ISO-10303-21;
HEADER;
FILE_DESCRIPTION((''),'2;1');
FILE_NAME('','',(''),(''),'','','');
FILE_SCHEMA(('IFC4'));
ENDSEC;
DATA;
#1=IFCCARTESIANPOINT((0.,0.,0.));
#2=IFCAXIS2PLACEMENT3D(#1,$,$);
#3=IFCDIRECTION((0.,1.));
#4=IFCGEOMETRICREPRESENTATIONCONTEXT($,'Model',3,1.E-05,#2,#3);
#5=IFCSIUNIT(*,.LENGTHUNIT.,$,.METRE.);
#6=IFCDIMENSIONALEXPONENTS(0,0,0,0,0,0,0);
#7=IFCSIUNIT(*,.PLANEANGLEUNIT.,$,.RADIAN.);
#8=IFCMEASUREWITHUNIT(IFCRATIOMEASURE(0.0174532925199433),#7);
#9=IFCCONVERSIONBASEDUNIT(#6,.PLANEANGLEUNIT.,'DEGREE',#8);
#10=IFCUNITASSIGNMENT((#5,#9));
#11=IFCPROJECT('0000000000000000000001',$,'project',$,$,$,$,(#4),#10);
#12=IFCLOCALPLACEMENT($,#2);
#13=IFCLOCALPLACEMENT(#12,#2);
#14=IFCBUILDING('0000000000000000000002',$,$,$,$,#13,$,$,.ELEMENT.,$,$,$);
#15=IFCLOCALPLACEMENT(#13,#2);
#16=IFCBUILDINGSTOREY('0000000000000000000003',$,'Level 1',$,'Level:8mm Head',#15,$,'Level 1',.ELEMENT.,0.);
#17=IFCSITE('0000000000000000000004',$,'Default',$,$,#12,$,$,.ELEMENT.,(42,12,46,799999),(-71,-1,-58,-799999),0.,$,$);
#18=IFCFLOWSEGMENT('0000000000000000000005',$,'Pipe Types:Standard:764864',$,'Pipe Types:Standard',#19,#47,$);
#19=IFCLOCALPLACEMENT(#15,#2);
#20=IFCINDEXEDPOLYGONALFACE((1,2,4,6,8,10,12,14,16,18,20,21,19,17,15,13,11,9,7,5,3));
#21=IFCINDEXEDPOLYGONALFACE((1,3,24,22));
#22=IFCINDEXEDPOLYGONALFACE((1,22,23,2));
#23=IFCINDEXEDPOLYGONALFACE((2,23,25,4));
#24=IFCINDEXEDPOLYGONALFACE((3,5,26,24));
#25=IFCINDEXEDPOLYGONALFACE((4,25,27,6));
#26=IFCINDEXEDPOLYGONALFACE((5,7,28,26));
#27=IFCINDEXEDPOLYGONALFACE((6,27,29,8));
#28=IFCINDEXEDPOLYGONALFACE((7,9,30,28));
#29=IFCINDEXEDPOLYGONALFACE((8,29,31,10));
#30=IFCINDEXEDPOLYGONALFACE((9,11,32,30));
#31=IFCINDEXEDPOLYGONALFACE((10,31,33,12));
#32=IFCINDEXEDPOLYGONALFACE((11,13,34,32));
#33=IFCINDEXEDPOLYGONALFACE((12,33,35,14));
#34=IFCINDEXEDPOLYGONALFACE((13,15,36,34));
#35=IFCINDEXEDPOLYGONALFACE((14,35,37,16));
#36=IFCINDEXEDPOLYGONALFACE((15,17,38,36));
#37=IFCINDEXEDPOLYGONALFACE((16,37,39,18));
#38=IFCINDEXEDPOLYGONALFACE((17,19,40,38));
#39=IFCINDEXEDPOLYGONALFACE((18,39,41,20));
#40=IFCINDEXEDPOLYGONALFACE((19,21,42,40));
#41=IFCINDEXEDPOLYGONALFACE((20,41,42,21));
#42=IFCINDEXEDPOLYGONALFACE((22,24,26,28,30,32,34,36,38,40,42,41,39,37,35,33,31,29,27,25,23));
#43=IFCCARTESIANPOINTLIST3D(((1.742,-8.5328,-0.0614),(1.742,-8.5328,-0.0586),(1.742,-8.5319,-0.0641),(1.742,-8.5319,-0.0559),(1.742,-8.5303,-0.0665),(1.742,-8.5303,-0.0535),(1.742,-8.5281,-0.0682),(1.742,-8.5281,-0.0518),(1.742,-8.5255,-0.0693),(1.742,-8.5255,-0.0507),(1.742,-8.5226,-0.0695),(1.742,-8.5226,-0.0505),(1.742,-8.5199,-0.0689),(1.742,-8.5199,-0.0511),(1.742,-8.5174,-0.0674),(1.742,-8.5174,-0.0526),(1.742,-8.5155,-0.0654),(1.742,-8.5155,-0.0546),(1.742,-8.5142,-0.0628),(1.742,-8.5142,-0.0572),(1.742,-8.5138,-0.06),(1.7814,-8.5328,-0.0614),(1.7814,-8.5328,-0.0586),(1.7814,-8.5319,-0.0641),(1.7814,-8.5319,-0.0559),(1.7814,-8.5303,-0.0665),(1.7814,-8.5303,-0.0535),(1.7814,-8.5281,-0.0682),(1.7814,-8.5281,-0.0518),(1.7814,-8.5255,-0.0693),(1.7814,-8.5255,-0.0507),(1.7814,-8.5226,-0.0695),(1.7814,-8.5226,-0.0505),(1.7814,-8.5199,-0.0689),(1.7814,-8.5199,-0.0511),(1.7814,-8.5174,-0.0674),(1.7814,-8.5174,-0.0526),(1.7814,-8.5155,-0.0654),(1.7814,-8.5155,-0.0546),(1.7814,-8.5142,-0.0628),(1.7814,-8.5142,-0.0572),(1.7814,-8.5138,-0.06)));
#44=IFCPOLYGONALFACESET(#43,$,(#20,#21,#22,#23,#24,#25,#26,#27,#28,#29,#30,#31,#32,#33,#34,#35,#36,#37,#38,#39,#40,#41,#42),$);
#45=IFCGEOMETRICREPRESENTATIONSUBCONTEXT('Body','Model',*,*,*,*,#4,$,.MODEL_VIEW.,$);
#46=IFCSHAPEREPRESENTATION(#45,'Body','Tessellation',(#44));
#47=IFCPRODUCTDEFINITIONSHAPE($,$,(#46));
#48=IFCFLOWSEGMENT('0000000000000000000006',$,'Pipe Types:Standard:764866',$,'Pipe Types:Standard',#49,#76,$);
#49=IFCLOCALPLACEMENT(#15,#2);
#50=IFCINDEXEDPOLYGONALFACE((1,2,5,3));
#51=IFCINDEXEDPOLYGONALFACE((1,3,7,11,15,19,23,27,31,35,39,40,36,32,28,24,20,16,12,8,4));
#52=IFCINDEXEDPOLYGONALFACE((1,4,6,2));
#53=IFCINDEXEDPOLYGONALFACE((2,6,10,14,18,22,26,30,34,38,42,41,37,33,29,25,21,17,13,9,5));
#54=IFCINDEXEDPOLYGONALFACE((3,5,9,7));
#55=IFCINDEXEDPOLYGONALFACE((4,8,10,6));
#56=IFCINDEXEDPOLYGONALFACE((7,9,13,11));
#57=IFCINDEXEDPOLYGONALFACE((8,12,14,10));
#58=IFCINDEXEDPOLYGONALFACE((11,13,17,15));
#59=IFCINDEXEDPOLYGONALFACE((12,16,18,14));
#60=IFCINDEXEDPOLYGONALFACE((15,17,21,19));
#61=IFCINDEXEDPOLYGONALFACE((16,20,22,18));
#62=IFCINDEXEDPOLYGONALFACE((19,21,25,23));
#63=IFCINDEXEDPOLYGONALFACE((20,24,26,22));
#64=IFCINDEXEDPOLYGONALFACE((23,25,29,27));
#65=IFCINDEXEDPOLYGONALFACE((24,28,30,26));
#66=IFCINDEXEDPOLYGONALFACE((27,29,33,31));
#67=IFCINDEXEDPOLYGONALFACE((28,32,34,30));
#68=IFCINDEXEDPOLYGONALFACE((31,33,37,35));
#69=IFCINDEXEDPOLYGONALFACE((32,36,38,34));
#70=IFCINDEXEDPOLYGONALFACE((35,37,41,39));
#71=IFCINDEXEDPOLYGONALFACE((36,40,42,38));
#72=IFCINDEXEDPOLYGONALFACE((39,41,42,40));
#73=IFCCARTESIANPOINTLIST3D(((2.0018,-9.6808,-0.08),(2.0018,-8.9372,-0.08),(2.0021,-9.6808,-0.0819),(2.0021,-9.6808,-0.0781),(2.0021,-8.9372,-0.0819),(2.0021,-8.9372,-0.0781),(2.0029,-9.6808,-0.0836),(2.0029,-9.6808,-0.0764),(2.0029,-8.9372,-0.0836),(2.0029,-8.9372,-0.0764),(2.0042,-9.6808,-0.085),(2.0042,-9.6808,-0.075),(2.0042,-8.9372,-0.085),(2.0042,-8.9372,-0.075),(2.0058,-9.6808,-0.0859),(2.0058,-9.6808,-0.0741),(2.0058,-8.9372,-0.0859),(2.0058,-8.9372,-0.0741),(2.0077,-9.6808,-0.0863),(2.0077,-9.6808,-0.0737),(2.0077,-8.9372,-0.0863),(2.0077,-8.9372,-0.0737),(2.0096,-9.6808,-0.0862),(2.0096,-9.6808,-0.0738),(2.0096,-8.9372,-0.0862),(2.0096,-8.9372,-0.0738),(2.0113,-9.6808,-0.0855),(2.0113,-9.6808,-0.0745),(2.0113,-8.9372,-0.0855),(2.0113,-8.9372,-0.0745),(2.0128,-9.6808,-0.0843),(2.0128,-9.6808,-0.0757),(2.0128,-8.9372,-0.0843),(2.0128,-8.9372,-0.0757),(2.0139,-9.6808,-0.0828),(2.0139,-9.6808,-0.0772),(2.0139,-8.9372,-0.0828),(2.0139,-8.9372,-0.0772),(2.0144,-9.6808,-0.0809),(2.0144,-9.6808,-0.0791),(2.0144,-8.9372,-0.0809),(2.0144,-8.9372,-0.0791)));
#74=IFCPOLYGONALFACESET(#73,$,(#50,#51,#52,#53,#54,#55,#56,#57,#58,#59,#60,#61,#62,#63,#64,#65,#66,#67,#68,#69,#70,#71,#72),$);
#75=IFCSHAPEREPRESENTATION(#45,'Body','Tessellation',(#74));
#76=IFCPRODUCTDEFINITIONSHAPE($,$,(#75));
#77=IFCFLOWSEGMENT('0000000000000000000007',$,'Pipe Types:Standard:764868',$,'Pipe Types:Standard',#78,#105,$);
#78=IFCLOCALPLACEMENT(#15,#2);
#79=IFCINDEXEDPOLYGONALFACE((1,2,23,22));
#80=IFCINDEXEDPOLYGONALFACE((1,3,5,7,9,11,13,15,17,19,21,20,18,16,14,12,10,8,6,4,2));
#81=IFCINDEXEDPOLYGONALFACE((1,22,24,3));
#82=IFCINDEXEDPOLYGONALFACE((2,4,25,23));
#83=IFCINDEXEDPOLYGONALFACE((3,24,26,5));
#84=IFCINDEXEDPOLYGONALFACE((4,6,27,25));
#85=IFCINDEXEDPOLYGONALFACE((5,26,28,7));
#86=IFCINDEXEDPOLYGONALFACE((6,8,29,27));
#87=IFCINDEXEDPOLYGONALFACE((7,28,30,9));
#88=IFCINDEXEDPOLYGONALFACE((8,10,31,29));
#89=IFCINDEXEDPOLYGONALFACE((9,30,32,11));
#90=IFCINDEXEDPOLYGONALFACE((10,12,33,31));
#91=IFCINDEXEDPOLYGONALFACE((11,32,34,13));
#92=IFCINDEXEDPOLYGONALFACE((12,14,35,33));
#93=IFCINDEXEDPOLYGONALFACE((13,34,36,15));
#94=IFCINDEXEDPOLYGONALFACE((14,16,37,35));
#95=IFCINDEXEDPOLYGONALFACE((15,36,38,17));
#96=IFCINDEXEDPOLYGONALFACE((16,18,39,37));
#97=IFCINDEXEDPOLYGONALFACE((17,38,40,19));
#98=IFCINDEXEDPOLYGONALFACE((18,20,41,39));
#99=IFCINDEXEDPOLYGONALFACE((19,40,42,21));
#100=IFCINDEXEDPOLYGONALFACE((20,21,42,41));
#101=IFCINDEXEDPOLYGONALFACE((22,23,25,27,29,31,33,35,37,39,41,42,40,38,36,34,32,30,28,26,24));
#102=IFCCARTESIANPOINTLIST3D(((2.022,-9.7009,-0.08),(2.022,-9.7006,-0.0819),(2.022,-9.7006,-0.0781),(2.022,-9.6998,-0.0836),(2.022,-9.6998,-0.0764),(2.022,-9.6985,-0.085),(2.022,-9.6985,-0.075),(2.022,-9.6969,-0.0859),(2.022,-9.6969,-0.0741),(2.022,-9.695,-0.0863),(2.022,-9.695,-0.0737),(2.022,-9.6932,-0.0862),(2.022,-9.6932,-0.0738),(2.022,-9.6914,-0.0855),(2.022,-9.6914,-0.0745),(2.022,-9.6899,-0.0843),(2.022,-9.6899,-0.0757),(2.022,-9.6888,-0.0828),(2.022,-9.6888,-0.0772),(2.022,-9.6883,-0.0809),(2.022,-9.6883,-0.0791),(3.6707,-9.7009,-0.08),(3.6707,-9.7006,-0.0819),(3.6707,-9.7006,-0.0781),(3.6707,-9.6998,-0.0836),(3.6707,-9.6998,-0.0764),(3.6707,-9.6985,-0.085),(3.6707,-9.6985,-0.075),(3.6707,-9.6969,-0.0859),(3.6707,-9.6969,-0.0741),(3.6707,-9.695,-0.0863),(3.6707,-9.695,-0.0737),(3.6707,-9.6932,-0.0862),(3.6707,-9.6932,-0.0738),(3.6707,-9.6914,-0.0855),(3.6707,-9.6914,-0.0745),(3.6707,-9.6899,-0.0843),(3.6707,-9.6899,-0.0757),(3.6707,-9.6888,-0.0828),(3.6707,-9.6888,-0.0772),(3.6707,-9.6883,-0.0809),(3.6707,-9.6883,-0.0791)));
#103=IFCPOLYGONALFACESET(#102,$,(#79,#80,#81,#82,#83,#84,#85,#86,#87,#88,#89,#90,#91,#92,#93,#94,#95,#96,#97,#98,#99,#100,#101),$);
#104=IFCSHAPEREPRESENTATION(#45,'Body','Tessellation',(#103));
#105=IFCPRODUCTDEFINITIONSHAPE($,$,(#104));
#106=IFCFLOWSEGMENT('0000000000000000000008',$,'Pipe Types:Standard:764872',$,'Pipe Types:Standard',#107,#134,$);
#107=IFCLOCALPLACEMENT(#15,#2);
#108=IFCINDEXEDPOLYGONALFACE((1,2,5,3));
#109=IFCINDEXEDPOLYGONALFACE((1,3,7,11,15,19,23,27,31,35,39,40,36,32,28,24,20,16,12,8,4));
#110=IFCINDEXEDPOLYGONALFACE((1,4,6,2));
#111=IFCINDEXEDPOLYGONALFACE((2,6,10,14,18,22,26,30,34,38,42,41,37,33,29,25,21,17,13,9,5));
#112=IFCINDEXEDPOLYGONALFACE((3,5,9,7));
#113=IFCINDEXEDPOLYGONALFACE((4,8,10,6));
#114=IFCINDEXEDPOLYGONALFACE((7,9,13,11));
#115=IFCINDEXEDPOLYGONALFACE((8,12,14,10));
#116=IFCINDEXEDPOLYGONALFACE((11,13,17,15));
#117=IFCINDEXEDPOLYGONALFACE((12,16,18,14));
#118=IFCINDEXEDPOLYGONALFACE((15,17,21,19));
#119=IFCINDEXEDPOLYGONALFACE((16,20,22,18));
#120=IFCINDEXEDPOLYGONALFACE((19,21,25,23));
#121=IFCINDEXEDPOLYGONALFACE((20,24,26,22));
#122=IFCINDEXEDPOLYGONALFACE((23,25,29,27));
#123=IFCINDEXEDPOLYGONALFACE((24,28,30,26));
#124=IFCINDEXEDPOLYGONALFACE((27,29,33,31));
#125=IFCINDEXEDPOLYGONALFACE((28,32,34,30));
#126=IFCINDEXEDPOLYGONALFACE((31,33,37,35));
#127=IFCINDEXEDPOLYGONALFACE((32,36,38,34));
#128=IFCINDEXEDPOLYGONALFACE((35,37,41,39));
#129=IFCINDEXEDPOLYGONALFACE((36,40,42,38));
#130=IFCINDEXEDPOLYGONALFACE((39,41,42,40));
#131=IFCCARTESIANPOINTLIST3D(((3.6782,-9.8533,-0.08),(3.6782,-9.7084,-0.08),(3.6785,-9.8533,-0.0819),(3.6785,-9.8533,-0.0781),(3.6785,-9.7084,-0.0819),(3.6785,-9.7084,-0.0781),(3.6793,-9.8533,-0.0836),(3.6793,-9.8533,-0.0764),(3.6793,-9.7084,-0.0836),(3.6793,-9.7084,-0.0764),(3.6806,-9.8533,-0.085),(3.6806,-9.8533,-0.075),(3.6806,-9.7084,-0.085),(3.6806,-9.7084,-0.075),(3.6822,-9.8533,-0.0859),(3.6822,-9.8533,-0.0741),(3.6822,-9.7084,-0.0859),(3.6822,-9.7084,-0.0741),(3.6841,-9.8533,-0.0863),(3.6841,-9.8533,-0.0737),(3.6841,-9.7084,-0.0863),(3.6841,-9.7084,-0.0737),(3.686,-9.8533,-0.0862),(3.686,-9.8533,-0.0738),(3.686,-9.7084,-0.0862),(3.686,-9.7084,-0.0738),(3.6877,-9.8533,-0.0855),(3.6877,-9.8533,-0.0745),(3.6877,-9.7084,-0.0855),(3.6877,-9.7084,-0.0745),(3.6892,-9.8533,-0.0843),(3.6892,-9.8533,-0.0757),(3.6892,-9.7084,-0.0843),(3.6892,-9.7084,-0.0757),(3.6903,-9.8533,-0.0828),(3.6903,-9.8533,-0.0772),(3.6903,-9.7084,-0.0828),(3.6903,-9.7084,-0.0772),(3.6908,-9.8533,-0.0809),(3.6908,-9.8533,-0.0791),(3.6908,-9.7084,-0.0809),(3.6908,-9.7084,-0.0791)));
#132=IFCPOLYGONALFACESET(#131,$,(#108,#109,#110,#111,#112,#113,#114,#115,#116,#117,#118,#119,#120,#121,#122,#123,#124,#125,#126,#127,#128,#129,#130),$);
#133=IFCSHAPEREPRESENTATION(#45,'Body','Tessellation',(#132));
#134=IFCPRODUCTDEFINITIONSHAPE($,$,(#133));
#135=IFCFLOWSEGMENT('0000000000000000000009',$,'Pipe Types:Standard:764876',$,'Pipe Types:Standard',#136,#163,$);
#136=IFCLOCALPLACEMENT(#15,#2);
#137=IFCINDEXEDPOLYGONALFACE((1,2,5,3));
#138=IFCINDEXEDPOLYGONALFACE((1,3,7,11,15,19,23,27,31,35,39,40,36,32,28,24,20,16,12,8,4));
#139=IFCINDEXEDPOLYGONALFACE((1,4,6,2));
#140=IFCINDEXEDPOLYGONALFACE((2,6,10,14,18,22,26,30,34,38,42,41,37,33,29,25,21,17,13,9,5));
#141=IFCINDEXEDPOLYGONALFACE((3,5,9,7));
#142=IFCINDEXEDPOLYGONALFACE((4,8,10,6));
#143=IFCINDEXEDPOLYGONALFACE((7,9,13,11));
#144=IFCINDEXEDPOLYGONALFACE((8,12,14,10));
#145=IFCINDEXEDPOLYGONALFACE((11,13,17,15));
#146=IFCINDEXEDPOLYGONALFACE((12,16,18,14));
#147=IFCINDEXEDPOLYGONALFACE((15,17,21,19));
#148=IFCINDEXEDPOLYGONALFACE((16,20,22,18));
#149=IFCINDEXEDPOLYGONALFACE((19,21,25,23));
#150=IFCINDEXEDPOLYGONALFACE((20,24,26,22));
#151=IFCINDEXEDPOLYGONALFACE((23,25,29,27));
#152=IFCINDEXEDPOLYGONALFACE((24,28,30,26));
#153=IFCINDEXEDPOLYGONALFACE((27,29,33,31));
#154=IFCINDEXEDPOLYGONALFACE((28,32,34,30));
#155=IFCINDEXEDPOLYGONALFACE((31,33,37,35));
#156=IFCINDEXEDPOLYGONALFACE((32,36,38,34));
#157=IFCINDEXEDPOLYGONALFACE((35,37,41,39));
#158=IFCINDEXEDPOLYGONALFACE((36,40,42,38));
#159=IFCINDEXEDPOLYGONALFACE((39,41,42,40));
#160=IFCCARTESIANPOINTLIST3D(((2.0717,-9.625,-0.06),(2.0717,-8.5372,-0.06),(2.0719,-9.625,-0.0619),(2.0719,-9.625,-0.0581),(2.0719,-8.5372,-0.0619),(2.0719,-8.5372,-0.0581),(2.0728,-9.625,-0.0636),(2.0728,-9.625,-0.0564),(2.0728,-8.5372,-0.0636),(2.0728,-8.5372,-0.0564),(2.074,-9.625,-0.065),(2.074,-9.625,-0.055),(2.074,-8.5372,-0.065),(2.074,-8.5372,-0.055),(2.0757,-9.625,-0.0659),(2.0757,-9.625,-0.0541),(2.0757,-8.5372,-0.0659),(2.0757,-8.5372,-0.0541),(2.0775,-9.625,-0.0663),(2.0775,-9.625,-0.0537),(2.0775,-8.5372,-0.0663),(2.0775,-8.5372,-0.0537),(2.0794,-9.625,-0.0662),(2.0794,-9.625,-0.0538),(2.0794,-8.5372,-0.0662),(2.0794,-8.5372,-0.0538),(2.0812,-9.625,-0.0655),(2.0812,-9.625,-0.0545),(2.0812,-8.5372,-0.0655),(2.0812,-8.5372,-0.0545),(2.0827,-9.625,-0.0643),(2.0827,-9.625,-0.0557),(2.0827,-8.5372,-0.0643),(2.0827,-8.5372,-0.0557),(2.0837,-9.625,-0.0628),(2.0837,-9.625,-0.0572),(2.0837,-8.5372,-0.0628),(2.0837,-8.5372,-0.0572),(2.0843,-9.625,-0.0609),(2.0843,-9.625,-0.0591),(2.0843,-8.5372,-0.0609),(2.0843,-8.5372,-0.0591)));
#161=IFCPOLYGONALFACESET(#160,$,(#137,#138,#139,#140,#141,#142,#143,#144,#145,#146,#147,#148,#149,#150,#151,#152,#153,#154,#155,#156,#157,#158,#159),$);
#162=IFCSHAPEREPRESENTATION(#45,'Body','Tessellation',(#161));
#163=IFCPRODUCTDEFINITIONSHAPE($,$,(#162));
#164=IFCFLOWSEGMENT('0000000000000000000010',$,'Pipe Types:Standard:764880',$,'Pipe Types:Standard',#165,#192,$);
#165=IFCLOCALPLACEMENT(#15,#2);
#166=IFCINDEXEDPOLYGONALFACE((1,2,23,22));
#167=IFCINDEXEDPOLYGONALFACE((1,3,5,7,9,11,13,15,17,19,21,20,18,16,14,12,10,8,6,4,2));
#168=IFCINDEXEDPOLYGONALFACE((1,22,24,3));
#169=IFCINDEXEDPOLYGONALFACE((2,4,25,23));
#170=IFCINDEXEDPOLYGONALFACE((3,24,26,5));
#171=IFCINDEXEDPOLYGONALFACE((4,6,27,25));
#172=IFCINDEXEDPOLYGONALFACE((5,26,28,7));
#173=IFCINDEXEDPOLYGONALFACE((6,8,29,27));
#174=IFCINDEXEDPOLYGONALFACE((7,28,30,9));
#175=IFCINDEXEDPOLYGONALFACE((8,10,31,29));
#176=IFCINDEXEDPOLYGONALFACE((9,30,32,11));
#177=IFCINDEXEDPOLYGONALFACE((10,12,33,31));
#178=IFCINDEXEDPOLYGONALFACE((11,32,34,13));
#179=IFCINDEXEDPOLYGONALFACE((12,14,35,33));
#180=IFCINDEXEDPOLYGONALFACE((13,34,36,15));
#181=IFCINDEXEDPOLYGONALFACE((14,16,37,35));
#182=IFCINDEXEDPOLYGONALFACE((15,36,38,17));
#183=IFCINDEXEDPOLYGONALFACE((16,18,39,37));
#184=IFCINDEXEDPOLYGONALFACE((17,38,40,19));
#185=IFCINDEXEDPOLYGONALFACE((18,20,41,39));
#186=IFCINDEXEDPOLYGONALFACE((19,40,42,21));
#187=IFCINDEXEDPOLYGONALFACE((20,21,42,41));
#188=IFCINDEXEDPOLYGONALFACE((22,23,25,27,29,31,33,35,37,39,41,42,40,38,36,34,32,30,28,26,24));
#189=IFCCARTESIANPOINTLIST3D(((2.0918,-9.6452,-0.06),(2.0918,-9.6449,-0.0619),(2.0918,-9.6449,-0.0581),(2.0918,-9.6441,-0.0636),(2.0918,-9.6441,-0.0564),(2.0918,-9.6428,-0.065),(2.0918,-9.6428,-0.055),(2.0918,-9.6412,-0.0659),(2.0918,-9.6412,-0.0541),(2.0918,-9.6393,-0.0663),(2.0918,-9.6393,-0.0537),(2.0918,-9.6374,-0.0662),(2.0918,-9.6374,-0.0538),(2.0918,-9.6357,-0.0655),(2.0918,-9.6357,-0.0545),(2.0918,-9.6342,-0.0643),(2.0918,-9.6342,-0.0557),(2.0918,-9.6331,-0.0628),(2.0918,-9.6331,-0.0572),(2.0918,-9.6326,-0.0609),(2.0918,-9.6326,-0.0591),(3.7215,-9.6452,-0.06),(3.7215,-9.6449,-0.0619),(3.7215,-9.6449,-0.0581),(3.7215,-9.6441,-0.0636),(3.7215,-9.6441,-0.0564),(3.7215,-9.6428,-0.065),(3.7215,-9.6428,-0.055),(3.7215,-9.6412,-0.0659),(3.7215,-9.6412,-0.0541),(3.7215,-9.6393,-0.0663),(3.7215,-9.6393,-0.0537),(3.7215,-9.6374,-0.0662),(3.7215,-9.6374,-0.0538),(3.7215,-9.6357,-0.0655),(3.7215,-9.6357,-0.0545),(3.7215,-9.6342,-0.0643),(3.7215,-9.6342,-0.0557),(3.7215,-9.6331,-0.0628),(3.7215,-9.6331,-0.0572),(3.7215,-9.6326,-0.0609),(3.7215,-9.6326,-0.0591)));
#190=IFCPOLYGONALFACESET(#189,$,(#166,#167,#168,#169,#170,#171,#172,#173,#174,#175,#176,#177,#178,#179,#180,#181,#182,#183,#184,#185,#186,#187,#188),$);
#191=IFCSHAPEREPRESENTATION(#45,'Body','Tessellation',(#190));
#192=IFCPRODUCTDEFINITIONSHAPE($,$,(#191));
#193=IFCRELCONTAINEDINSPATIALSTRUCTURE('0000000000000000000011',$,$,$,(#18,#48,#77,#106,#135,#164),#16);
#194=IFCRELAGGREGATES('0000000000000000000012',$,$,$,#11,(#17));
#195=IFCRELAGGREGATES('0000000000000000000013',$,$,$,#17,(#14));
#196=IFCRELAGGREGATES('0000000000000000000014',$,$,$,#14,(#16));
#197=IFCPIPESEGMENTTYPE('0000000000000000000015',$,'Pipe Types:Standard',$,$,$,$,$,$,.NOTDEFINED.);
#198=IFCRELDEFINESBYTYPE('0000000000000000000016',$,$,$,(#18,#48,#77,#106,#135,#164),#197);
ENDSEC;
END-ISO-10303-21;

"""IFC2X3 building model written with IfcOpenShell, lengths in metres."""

from ifc_helpers import new_model, entity, si_unit, converted_unit, direction, frame, frame_2d, origin, origin_2d_with_axis, place, context, subcontext, project, spatial, circle, extrude, type_object, element, save


model = new_model("IFC2X3")

# Units and contexts
model_context = context("Model", 3, precision=1e-05, world=origin(), true_north=direction((0.0, 1.0)))
body_context = subcontext(model_context, "Body", "Model", "MODEL_VIEW")
ifc_project = project(units=[si_unit("LENGTHUNIT", "METRE"), converted_unit("PLANEANGLEUNIT", "DEGREE", entity("IfcRatioMeasure", 0.0174532925199433), si_unit("PLANEANGLEUNIT", "RADIAN"), dimensions=[0, 0, 0, 0, 0, 0, 0])], contexts=[model_context])

# Site, building, storey
site_placement = place(None, origin())
site = spatial("IfcSite", under=ifc_project, at=site_placement, Name="Default", CompositionType="ELEMENT", RefLatitude=(42, 12, 46, 799999), RefLongitude=(-71, -1, -58, -799999), RefElevation=0.0)
building_placement = place(site_placement, origin())
building = spatial("IfcBuilding", under=site, at=building_placement, CompositionType="ELEMENT")
storey_placement = place(building_placement, origin())
storey = spatial("IfcBuildingStorey", under=building, at=storey_placement, Name="Level 1", ObjectType="Level:8mm Head", LongName="Level 1", CompositionType="ELEMENT", Elevation=0.0)

# Flow segments
pipe_segment_type = type_object("IfcPipeSegmentType", Name="Pipe Types:Standard", PredefinedType="NOTDEFINED")
flow_segment_1_placement = place(storey_placement, origin())
element("IfcFlowSegment", 1, at=flow_segment_1_placement, inside=storey, type_object=pipe_segment_type, Name="Pipe Types:Standard:764864", ObjectType="Pipe Types:Standard", context=body_context, shape_type="SweptSolid", body=[
    extrude(circle(Radius=0.0095, at=frame_2d((0.0, 0.0), x_axis=(1.0, 0.0))), frame((1.742, -8.5234, -0.06), z_axis=(1.0, 0.0, 0.0), x_axis=(0.0, 1.0, 0.0)), (0.0, 0.0, 1.0), 0.0394),
])
flow_segment_2_placement = place(storey_placement, origin())
element("IfcFlowSegment", 2, at=flow_segment_2_placement, inside=storey, type_object=pipe_segment_type, Name="Pipe Types:Standard:764866", ObjectType="Pipe Types:Standard", context=body_context, shape_type="SweptSolid", body=[
    extrude(circle(Radius=0.0063, at=frame_2d((0.0, 0.0), x_axis=(1.0, 0.0))), frame((2.0082, -9.6808, -0.08), z_axis=(0.0, 1.0, 0.0), x_axis=(-1.0, 0.0, 0.0)), (0.0, 0.0, 1.0), 0.7436),
])
flow_segment_3_placement = place(storey_placement, origin())
element("IfcFlowSegment", 3, at=flow_segment_3_placement, inside=storey, type_object=pipe_segment_type, Name="Pipe Types:Standard:764868", ObjectType="Pipe Types:Standard", context=body_context, shape_type="SweptSolid", body=[
    extrude(circle(Radius=0.0063, at=origin_2d_with_axis()), frame((2.022, -9.6946, -0.08), z_axis=(1.0, 0.0, 0.0), x_axis=(0.0, -1.0, 0.0)), (0.0, 0.0, 1.0), 1.6488),
])
flow_segment_4_placement = place(storey_placement, origin())
element("IfcFlowSegment", 4, at=flow_segment_4_placement, inside=storey, type_object=pipe_segment_type, Name="Pipe Types:Standard:764872", ObjectType="Pipe Types:Standard", context=body_context, shape_type="SweptSolid", body=[
    extrude(circle(Radius=0.0063, at=frame_2d((0.0, 0.0), x_axis=(1.0, 0.0))), frame((3.6845, -9.8533, -0.08), z_axis=(0.0, 1.0, 0.0), x_axis=(-1.0, 0.0, 0.0)), (0.0, 0.0, 1.0), 0.1449),
])
flow_segment_5_placement = place(storey_placement, origin())
element("IfcFlowSegment", 5, at=flow_segment_5_placement, inside=storey, type_object=pipe_segment_type, Name="Pipe Types:Standard:764876", ObjectType="Pipe Types:Standard", context=body_context, shape_type="SweptSolid", body=[
    extrude(circle(Radius=0.0063, at=frame_2d((0.0, 0.0), x_axis=(1.0, 0.0))), frame((2.078, -9.625, -0.06), z_axis=(0.0, 1.0, 0.0), x_axis=(-1.0, 0.0, 0.0)), (0.0, 0.0, 1.0), 1.0879),
])
flow_segment_6_placement = place(storey_placement, origin())
element("IfcFlowSegment", 6, at=flow_segment_6_placement, inside=storey, type_object=pipe_segment_type, Name="Pipe Types:Standard:764880", ObjectType="Pipe Types:Standard", context=body_context, shape_type="SweptSolid", body=[
    extrude(circle(Radius=0.0063, at=origin_2d_with_axis()), frame((2.0918, -9.6388, -0.06), z_axis=(1.0, 0.0, 0.0), x_axis=(0.0, -1.0, 0.0)), (0.0, 0.0, 1.0), 1.6297),
])

save(model, "model.ifc")
